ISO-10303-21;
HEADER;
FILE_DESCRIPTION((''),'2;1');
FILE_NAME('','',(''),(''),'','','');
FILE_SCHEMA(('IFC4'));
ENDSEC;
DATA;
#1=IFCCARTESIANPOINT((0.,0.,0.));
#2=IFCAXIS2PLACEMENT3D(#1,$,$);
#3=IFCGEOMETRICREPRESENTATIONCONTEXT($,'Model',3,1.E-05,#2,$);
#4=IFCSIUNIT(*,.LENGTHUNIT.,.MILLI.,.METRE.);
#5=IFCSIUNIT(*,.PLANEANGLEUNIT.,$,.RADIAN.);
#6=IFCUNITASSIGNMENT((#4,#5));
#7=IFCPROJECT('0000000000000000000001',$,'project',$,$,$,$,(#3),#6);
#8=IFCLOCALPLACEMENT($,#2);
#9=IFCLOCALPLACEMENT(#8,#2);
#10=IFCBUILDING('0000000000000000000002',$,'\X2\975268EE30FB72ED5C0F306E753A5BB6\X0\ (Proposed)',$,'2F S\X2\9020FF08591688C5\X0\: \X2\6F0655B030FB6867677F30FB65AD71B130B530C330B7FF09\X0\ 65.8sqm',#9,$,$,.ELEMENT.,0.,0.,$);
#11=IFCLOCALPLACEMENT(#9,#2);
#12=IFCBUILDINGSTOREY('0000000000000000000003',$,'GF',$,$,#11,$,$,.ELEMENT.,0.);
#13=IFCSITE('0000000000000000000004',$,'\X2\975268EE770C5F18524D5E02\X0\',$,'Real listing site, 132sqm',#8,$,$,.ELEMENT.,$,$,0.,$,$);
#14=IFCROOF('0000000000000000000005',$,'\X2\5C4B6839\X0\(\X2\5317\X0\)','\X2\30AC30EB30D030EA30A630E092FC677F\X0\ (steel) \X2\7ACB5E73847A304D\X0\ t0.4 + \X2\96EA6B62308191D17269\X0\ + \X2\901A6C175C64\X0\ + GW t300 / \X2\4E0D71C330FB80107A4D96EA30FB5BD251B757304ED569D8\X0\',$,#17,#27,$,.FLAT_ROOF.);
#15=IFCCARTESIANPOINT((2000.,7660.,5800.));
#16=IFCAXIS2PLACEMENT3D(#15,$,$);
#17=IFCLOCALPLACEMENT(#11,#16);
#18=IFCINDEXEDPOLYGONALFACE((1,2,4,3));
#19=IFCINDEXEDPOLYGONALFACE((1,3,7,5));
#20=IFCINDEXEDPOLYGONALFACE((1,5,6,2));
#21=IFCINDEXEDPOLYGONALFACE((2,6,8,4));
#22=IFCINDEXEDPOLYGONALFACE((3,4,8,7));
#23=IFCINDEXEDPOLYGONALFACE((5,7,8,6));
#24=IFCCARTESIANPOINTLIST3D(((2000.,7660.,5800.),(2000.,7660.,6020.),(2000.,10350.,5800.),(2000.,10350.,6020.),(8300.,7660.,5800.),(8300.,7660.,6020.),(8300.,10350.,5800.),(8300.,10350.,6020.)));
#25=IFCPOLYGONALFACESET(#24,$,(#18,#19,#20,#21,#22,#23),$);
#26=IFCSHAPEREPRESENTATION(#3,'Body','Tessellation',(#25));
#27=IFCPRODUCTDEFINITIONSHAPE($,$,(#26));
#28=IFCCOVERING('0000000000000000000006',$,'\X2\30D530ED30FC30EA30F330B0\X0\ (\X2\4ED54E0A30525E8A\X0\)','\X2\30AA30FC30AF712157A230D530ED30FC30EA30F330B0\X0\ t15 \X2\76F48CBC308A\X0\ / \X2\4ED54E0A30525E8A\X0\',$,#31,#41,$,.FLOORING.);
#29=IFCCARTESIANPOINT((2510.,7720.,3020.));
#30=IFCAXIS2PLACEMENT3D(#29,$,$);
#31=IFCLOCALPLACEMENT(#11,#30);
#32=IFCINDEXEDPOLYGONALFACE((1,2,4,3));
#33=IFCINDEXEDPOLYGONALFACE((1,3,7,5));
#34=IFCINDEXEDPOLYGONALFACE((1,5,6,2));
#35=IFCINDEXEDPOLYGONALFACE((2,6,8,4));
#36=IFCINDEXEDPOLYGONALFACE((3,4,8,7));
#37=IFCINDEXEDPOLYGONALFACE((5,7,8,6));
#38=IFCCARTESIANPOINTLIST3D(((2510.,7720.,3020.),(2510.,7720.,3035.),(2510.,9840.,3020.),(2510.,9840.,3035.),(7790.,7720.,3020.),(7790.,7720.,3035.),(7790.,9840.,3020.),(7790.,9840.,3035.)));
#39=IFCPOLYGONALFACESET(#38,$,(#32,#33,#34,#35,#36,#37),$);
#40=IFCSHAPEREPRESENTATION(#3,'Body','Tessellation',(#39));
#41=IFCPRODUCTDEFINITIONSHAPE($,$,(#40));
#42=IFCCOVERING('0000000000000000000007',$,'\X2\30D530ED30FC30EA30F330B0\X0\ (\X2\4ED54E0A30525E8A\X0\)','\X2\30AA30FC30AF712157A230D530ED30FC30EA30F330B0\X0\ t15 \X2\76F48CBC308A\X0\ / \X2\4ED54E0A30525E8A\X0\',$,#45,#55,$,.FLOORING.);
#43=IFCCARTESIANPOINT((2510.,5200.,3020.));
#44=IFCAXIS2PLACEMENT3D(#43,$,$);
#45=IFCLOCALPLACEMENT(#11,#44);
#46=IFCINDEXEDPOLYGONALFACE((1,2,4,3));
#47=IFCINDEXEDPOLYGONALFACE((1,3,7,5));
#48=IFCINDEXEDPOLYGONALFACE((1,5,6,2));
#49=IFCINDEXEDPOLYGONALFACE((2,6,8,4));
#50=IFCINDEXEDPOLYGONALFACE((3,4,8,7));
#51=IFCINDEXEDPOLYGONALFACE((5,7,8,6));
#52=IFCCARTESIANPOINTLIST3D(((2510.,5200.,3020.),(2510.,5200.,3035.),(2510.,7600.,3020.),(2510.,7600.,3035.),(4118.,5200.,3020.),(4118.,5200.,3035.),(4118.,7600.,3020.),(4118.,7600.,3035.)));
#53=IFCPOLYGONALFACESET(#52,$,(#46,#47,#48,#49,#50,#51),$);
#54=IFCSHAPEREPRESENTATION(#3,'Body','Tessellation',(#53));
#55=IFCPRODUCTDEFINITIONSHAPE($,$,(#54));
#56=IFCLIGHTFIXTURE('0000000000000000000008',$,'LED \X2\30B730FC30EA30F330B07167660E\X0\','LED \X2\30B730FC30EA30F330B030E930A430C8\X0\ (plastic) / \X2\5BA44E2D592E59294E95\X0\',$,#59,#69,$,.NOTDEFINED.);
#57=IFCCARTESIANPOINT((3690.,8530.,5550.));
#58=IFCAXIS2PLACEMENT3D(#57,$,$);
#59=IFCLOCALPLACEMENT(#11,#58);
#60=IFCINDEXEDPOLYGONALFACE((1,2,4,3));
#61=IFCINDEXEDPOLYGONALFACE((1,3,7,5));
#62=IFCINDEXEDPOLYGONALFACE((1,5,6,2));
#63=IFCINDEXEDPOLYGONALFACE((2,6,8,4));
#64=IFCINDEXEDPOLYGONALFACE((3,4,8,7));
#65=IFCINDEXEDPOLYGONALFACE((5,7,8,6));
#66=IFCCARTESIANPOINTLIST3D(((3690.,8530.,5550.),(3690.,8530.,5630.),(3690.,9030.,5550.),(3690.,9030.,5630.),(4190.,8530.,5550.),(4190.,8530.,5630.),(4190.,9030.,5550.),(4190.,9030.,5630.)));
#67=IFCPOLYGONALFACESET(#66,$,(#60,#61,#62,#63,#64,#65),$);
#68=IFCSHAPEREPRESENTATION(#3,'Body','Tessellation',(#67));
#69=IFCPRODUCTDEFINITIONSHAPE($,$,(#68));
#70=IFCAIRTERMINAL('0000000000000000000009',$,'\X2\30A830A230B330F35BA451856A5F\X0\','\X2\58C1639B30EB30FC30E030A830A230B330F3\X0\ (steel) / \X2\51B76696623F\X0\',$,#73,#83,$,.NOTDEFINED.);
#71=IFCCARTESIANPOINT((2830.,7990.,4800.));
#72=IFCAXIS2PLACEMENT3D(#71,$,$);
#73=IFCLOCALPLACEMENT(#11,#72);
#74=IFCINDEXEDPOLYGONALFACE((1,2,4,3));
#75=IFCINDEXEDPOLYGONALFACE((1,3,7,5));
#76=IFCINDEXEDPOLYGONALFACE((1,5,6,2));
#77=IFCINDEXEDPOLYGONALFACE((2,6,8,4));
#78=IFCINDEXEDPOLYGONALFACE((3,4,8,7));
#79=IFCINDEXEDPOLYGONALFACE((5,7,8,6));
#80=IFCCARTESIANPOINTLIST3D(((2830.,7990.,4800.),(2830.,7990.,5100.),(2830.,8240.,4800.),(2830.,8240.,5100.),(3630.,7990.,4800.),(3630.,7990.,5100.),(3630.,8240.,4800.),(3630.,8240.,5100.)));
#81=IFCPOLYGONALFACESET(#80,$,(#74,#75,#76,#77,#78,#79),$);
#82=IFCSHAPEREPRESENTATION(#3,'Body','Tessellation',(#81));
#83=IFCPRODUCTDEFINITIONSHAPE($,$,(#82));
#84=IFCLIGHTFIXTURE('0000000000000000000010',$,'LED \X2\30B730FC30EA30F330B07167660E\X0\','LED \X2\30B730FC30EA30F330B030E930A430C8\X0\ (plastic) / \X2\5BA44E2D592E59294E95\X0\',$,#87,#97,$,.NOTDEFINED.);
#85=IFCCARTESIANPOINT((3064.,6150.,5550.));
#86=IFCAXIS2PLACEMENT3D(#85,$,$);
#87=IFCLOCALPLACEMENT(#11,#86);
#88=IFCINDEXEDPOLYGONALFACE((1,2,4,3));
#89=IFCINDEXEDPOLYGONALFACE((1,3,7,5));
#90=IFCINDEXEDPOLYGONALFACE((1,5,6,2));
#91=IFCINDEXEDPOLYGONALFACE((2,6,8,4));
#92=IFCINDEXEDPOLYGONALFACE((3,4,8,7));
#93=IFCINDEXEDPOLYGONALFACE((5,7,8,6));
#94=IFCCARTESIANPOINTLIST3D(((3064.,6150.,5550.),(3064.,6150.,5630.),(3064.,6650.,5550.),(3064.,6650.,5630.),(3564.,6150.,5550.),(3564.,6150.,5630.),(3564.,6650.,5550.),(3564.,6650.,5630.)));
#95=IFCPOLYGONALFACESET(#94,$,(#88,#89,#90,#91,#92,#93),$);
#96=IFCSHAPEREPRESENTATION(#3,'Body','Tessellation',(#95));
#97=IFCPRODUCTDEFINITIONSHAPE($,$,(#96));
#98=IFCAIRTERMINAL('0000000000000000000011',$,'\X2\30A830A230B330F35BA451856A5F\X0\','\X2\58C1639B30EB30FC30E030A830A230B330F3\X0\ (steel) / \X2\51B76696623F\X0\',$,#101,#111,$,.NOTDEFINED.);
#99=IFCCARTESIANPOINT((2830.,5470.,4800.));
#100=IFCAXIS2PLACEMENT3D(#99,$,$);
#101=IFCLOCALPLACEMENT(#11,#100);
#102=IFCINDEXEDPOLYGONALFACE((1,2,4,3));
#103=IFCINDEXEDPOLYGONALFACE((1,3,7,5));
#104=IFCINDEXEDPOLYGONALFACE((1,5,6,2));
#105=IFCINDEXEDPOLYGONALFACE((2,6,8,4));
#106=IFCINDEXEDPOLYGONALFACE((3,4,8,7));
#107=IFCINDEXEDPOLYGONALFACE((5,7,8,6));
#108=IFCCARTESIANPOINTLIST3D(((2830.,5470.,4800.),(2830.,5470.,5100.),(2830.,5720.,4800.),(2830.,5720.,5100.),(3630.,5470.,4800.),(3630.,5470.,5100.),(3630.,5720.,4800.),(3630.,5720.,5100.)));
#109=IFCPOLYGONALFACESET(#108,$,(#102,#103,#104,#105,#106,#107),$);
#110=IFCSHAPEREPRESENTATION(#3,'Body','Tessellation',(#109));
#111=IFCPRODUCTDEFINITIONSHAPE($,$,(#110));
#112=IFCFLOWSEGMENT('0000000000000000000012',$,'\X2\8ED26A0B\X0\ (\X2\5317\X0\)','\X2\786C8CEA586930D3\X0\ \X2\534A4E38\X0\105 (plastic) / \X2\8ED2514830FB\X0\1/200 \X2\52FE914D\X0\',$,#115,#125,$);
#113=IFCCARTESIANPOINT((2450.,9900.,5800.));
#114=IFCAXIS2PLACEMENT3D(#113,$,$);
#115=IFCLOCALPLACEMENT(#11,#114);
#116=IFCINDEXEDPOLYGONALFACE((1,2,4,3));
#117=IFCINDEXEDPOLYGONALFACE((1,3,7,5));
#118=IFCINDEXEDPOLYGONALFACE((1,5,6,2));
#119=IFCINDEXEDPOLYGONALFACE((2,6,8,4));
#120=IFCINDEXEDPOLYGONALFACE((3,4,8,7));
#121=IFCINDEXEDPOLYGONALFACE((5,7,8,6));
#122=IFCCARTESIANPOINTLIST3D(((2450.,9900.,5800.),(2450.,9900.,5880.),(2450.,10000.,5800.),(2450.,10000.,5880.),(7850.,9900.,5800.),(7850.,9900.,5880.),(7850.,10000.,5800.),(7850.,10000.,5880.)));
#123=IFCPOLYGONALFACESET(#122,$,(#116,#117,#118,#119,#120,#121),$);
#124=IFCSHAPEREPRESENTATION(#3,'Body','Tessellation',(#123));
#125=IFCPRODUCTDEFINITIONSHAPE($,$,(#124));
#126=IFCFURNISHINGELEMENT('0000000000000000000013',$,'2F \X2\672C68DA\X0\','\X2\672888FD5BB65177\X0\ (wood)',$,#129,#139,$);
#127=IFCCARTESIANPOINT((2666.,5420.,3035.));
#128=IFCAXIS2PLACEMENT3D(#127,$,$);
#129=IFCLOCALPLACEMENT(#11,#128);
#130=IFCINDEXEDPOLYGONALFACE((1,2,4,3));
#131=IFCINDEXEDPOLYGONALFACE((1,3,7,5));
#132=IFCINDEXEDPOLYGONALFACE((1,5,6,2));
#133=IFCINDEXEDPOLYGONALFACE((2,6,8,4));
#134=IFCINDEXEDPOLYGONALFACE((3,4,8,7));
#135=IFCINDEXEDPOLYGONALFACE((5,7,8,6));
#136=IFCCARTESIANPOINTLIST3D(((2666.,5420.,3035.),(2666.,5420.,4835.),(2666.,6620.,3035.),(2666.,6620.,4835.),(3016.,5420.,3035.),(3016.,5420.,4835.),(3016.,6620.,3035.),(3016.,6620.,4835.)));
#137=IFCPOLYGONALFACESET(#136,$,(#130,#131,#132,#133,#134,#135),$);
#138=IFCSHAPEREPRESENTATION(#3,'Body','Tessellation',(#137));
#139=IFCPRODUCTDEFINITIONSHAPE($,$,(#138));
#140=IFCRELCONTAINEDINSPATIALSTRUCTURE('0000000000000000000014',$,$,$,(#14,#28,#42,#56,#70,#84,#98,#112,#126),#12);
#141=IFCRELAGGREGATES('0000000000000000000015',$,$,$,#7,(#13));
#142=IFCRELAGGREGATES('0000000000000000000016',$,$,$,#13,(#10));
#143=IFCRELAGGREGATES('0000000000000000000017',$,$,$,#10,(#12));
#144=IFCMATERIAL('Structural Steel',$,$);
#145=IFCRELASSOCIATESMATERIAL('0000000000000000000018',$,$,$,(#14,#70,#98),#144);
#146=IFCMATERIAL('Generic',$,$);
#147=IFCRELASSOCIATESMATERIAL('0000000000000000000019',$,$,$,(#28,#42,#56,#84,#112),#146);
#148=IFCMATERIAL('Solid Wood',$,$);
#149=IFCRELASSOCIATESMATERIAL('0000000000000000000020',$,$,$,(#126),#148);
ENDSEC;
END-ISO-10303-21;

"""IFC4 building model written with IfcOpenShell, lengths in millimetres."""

from ifc_helpers import new_model, si_unit, frame, frame_2d, origin, place, context, project, spatial, rectangle, extrude, material, element, save


model = new_model("IFC4")

# Units and contexts
model_context = context("Model", 3, precision=1e-05, world=origin())
ifc_project = project(units=[si_unit("LENGTHUNIT", "METRE", prefix="MILLI"), si_unit("PLANEANGLEUNIT", "RADIAN")], contexts=[model_context])

# Site, building, storey
site_placement = place(None, origin())
site = spatial("IfcSite", under=ifc_project, at=site_placement, Name="青森県弘前市", ObjectType="Real listing site, 132sqm", CompositionType="ELEMENT", RefElevation=0.0)
building_placement = place(site_placement, origin())
building = spatial("IfcBuilding", under=site, at=building_placement, Name="青森・狭小の町家 (Proposed)", ObjectType="2F S造（外装: 漆喰・桧板・断熱サッシ） 65.8sqm", CompositionType="ELEMENT", ElevationOfRefHeight=0.0, ElevationOfTerrain=0.0)
storey_placement = place(building_placement, origin())
storey = spatial("IfcBuildingStorey", under=building, at=storey_placement, Name="GF", CompositionType="ELEMENT", Elevation=0.0)

# Shared definitions
ifc_material_1 = material(Name="Solid Wood")

# Roof
ifc_material_2 = material(Name="Structural Steel")
for number, where, name in (
    (1, (2000.0, 7660.0, 5800.0), "屋根(北)"),
):
    element("IfcRoof", number, at=place(storey_placement, frame(where)), inside=storey, material=ifc_material_2, Name=name, Description="ガルバリウム鋼板 (steel) 立平葺き t0.4 + 雪止め金物 + 通気層 + GW t300 / 不燃・耐積雪・寒冷地仕様", PredefinedType="FLAT_ROOF", context=model_context, shape_type="SweptSolid", body=[
        extrude(rectangle(XDim=6300.0, YDim=2690.0, at=frame_2d((3150.0, 1345.0))), frame((2000.0, 7660.0, 5800.0)), (0.0, 0.0, 1.0), 220.0),
    ])

# Coverings
ifc_material_3 = material(Name="Generic")
covering_1_placement = place(storey_placement, frame((2510.0, 7720.0, 3020.0)))
element("IfcCovering", 2, at=covering_1_placement, inside=storey, material=ifc_material_3, Name="フローリング (仕上げ床)", Description="オーク無垢フローリング t15 直貼り / 仕上げ床", PredefinedType="FLOORING", context=model_context, shape_type="SweptSolid", body=[
    extrude(rectangle(XDim=5280.0, YDim=2120.0, at=frame_2d((2640.0, 1060.0))), frame((2510.0, 7720.0, 3020.0)), (0.0, 0.0, 1.0), 15.0),
])
covering_2_placement = place(storey_placement, frame((2510.0, 5200.0, 3020.0)))
element("IfcCovering", 3, at=covering_2_placement, inside=storey, material=ifc_material_3, Name="フローリング (仕上げ床)", Description="オーク無垢フローリング t15 直貼り / 仕上げ床", PredefinedType="FLOORING", context=model_context, shape_type="SweptSolid", body=[
    extrude(rectangle(XDim=1608.0, YDim=2400.0, at=frame_2d((804.0, 1200.0))), frame((2510.0, 5200.0, 3020.0)), (0.0, 0.0, 1.0), 15.0),
])

# Light fixture
light_fixture_1_placement = place(storey_placement, frame((3690.0, 8530.0, 5550.0)))
element("IfcLightFixture", 4, at=light_fixture_1_placement, inside=storey, material=ifc_material_3, Name="LED シーリング照明", Description="LED シーリングライト (plastic) / 室中央天井", PredefinedType="NOTDEFINED", context=model_context, shape_type="SweptSolid", body=[
    extrude(rectangle(XDim=500.0, YDim=500.0, at=frame_2d((250.0, 250.0))), frame((3690.0, 8530.0, 5550.0)), (0.0, 0.0, 1.0), 80.0),
])

# Air terminal
air_terminal_1_placement = place(storey_placement, frame((2830.0, 7990.0, 4800.0)))
element("IfcAirTerminal", 5, at=air_terminal_1_placement, inside=storey, material=ifc_material_2, Name="エアコン室内機", Description="壁掛ルームエアコン (steel) / 冷暖房", PredefinedType="NOTDEFINED", context=model_context, shape_type="SweptSolid", body=[
    extrude(rectangle(XDim=800.0, YDim=250.0, at=frame_2d((400.0, 125.0))), frame((2830.0, 7990.0, 4800.0)), (0.0, 0.0, 1.0), 300.0),
])

# Light fixture
light_fixture_2_placement = place(storey_placement, frame((3064.0, 6150.0, 5550.0)))
element("IfcLightFixture", 6, at=light_fixture_2_placement, inside=storey, material=ifc_material_3, Name="LED シーリング照明", Description="LED シーリングライト (plastic) / 室中央天井", PredefinedType="NOTDEFINED", context=model_context, shape_type="SweptSolid", body=[
    extrude(rectangle(XDim=500.0, YDim=500.0, at=frame_2d((250.0, 250.0))), frame((3064.0, 6150.0, 5550.0)), (0.0, 0.0, 1.0), 80.0),
])

# Air terminal
air_terminal_2_placement = place(storey_placement, frame((2830.0, 5470.0, 4800.0)))
element("IfcAirTerminal", 7, at=air_terminal_2_placement, inside=storey, material=ifc_material_2, Name="エアコン室内機", Description="壁掛ルームエアコン (steel) / 冷暖房", PredefinedType="NOTDEFINED", context=model_context, shape_type="SweptSolid", body=[
    extrude(rectangle(XDim=800.0, YDim=250.0, at=frame_2d((400.0, 125.0))), frame((2830.0, 5470.0, 4800.0)), (0.0, 0.0, 1.0), 300.0),
])

# Flow segment
flow_segment_placement = place(storey_placement, frame((2450.0, 9900.0, 5800.0)))
element("IfcFlowSegment", 8, at=flow_segment_placement, inside=storey, material=ifc_material_3, Name="軒樋 (北)", Description="硬質塩ビ 半丸105 (plastic) / 軒先・1/200 勾配", context=model_context, shape_type="SweptSolid", body=[
    extrude(rectangle(XDim=5400.0, YDim=100.0, at=frame_2d((2700.0, 50.0))), frame((2450.0, 9900.0, 5800.0)), (0.0, 0.0, 1.0), 80.0),
])

# Furnishing element
furnishing_placement = place(storey_placement, frame((2666.0, 5420.0, 3035.0)))
element("IfcFurnishingElement", 9, at=furnishing_placement, inside=storey, material=ifc_material_1, Name="2F 本棚", Description="木製家具 (wood)", context=model_context, shape_type="SweptSolid", body=[
    extrude(rectangle(XDim=350.0, YDim=1200.0, at=frame_2d((175.0, 600.0))), frame((2666.0, 5420.0, 3035.0)), (0.0, 0.0, 1.0), 1800.0),
])

save(model, "model.ifc")
